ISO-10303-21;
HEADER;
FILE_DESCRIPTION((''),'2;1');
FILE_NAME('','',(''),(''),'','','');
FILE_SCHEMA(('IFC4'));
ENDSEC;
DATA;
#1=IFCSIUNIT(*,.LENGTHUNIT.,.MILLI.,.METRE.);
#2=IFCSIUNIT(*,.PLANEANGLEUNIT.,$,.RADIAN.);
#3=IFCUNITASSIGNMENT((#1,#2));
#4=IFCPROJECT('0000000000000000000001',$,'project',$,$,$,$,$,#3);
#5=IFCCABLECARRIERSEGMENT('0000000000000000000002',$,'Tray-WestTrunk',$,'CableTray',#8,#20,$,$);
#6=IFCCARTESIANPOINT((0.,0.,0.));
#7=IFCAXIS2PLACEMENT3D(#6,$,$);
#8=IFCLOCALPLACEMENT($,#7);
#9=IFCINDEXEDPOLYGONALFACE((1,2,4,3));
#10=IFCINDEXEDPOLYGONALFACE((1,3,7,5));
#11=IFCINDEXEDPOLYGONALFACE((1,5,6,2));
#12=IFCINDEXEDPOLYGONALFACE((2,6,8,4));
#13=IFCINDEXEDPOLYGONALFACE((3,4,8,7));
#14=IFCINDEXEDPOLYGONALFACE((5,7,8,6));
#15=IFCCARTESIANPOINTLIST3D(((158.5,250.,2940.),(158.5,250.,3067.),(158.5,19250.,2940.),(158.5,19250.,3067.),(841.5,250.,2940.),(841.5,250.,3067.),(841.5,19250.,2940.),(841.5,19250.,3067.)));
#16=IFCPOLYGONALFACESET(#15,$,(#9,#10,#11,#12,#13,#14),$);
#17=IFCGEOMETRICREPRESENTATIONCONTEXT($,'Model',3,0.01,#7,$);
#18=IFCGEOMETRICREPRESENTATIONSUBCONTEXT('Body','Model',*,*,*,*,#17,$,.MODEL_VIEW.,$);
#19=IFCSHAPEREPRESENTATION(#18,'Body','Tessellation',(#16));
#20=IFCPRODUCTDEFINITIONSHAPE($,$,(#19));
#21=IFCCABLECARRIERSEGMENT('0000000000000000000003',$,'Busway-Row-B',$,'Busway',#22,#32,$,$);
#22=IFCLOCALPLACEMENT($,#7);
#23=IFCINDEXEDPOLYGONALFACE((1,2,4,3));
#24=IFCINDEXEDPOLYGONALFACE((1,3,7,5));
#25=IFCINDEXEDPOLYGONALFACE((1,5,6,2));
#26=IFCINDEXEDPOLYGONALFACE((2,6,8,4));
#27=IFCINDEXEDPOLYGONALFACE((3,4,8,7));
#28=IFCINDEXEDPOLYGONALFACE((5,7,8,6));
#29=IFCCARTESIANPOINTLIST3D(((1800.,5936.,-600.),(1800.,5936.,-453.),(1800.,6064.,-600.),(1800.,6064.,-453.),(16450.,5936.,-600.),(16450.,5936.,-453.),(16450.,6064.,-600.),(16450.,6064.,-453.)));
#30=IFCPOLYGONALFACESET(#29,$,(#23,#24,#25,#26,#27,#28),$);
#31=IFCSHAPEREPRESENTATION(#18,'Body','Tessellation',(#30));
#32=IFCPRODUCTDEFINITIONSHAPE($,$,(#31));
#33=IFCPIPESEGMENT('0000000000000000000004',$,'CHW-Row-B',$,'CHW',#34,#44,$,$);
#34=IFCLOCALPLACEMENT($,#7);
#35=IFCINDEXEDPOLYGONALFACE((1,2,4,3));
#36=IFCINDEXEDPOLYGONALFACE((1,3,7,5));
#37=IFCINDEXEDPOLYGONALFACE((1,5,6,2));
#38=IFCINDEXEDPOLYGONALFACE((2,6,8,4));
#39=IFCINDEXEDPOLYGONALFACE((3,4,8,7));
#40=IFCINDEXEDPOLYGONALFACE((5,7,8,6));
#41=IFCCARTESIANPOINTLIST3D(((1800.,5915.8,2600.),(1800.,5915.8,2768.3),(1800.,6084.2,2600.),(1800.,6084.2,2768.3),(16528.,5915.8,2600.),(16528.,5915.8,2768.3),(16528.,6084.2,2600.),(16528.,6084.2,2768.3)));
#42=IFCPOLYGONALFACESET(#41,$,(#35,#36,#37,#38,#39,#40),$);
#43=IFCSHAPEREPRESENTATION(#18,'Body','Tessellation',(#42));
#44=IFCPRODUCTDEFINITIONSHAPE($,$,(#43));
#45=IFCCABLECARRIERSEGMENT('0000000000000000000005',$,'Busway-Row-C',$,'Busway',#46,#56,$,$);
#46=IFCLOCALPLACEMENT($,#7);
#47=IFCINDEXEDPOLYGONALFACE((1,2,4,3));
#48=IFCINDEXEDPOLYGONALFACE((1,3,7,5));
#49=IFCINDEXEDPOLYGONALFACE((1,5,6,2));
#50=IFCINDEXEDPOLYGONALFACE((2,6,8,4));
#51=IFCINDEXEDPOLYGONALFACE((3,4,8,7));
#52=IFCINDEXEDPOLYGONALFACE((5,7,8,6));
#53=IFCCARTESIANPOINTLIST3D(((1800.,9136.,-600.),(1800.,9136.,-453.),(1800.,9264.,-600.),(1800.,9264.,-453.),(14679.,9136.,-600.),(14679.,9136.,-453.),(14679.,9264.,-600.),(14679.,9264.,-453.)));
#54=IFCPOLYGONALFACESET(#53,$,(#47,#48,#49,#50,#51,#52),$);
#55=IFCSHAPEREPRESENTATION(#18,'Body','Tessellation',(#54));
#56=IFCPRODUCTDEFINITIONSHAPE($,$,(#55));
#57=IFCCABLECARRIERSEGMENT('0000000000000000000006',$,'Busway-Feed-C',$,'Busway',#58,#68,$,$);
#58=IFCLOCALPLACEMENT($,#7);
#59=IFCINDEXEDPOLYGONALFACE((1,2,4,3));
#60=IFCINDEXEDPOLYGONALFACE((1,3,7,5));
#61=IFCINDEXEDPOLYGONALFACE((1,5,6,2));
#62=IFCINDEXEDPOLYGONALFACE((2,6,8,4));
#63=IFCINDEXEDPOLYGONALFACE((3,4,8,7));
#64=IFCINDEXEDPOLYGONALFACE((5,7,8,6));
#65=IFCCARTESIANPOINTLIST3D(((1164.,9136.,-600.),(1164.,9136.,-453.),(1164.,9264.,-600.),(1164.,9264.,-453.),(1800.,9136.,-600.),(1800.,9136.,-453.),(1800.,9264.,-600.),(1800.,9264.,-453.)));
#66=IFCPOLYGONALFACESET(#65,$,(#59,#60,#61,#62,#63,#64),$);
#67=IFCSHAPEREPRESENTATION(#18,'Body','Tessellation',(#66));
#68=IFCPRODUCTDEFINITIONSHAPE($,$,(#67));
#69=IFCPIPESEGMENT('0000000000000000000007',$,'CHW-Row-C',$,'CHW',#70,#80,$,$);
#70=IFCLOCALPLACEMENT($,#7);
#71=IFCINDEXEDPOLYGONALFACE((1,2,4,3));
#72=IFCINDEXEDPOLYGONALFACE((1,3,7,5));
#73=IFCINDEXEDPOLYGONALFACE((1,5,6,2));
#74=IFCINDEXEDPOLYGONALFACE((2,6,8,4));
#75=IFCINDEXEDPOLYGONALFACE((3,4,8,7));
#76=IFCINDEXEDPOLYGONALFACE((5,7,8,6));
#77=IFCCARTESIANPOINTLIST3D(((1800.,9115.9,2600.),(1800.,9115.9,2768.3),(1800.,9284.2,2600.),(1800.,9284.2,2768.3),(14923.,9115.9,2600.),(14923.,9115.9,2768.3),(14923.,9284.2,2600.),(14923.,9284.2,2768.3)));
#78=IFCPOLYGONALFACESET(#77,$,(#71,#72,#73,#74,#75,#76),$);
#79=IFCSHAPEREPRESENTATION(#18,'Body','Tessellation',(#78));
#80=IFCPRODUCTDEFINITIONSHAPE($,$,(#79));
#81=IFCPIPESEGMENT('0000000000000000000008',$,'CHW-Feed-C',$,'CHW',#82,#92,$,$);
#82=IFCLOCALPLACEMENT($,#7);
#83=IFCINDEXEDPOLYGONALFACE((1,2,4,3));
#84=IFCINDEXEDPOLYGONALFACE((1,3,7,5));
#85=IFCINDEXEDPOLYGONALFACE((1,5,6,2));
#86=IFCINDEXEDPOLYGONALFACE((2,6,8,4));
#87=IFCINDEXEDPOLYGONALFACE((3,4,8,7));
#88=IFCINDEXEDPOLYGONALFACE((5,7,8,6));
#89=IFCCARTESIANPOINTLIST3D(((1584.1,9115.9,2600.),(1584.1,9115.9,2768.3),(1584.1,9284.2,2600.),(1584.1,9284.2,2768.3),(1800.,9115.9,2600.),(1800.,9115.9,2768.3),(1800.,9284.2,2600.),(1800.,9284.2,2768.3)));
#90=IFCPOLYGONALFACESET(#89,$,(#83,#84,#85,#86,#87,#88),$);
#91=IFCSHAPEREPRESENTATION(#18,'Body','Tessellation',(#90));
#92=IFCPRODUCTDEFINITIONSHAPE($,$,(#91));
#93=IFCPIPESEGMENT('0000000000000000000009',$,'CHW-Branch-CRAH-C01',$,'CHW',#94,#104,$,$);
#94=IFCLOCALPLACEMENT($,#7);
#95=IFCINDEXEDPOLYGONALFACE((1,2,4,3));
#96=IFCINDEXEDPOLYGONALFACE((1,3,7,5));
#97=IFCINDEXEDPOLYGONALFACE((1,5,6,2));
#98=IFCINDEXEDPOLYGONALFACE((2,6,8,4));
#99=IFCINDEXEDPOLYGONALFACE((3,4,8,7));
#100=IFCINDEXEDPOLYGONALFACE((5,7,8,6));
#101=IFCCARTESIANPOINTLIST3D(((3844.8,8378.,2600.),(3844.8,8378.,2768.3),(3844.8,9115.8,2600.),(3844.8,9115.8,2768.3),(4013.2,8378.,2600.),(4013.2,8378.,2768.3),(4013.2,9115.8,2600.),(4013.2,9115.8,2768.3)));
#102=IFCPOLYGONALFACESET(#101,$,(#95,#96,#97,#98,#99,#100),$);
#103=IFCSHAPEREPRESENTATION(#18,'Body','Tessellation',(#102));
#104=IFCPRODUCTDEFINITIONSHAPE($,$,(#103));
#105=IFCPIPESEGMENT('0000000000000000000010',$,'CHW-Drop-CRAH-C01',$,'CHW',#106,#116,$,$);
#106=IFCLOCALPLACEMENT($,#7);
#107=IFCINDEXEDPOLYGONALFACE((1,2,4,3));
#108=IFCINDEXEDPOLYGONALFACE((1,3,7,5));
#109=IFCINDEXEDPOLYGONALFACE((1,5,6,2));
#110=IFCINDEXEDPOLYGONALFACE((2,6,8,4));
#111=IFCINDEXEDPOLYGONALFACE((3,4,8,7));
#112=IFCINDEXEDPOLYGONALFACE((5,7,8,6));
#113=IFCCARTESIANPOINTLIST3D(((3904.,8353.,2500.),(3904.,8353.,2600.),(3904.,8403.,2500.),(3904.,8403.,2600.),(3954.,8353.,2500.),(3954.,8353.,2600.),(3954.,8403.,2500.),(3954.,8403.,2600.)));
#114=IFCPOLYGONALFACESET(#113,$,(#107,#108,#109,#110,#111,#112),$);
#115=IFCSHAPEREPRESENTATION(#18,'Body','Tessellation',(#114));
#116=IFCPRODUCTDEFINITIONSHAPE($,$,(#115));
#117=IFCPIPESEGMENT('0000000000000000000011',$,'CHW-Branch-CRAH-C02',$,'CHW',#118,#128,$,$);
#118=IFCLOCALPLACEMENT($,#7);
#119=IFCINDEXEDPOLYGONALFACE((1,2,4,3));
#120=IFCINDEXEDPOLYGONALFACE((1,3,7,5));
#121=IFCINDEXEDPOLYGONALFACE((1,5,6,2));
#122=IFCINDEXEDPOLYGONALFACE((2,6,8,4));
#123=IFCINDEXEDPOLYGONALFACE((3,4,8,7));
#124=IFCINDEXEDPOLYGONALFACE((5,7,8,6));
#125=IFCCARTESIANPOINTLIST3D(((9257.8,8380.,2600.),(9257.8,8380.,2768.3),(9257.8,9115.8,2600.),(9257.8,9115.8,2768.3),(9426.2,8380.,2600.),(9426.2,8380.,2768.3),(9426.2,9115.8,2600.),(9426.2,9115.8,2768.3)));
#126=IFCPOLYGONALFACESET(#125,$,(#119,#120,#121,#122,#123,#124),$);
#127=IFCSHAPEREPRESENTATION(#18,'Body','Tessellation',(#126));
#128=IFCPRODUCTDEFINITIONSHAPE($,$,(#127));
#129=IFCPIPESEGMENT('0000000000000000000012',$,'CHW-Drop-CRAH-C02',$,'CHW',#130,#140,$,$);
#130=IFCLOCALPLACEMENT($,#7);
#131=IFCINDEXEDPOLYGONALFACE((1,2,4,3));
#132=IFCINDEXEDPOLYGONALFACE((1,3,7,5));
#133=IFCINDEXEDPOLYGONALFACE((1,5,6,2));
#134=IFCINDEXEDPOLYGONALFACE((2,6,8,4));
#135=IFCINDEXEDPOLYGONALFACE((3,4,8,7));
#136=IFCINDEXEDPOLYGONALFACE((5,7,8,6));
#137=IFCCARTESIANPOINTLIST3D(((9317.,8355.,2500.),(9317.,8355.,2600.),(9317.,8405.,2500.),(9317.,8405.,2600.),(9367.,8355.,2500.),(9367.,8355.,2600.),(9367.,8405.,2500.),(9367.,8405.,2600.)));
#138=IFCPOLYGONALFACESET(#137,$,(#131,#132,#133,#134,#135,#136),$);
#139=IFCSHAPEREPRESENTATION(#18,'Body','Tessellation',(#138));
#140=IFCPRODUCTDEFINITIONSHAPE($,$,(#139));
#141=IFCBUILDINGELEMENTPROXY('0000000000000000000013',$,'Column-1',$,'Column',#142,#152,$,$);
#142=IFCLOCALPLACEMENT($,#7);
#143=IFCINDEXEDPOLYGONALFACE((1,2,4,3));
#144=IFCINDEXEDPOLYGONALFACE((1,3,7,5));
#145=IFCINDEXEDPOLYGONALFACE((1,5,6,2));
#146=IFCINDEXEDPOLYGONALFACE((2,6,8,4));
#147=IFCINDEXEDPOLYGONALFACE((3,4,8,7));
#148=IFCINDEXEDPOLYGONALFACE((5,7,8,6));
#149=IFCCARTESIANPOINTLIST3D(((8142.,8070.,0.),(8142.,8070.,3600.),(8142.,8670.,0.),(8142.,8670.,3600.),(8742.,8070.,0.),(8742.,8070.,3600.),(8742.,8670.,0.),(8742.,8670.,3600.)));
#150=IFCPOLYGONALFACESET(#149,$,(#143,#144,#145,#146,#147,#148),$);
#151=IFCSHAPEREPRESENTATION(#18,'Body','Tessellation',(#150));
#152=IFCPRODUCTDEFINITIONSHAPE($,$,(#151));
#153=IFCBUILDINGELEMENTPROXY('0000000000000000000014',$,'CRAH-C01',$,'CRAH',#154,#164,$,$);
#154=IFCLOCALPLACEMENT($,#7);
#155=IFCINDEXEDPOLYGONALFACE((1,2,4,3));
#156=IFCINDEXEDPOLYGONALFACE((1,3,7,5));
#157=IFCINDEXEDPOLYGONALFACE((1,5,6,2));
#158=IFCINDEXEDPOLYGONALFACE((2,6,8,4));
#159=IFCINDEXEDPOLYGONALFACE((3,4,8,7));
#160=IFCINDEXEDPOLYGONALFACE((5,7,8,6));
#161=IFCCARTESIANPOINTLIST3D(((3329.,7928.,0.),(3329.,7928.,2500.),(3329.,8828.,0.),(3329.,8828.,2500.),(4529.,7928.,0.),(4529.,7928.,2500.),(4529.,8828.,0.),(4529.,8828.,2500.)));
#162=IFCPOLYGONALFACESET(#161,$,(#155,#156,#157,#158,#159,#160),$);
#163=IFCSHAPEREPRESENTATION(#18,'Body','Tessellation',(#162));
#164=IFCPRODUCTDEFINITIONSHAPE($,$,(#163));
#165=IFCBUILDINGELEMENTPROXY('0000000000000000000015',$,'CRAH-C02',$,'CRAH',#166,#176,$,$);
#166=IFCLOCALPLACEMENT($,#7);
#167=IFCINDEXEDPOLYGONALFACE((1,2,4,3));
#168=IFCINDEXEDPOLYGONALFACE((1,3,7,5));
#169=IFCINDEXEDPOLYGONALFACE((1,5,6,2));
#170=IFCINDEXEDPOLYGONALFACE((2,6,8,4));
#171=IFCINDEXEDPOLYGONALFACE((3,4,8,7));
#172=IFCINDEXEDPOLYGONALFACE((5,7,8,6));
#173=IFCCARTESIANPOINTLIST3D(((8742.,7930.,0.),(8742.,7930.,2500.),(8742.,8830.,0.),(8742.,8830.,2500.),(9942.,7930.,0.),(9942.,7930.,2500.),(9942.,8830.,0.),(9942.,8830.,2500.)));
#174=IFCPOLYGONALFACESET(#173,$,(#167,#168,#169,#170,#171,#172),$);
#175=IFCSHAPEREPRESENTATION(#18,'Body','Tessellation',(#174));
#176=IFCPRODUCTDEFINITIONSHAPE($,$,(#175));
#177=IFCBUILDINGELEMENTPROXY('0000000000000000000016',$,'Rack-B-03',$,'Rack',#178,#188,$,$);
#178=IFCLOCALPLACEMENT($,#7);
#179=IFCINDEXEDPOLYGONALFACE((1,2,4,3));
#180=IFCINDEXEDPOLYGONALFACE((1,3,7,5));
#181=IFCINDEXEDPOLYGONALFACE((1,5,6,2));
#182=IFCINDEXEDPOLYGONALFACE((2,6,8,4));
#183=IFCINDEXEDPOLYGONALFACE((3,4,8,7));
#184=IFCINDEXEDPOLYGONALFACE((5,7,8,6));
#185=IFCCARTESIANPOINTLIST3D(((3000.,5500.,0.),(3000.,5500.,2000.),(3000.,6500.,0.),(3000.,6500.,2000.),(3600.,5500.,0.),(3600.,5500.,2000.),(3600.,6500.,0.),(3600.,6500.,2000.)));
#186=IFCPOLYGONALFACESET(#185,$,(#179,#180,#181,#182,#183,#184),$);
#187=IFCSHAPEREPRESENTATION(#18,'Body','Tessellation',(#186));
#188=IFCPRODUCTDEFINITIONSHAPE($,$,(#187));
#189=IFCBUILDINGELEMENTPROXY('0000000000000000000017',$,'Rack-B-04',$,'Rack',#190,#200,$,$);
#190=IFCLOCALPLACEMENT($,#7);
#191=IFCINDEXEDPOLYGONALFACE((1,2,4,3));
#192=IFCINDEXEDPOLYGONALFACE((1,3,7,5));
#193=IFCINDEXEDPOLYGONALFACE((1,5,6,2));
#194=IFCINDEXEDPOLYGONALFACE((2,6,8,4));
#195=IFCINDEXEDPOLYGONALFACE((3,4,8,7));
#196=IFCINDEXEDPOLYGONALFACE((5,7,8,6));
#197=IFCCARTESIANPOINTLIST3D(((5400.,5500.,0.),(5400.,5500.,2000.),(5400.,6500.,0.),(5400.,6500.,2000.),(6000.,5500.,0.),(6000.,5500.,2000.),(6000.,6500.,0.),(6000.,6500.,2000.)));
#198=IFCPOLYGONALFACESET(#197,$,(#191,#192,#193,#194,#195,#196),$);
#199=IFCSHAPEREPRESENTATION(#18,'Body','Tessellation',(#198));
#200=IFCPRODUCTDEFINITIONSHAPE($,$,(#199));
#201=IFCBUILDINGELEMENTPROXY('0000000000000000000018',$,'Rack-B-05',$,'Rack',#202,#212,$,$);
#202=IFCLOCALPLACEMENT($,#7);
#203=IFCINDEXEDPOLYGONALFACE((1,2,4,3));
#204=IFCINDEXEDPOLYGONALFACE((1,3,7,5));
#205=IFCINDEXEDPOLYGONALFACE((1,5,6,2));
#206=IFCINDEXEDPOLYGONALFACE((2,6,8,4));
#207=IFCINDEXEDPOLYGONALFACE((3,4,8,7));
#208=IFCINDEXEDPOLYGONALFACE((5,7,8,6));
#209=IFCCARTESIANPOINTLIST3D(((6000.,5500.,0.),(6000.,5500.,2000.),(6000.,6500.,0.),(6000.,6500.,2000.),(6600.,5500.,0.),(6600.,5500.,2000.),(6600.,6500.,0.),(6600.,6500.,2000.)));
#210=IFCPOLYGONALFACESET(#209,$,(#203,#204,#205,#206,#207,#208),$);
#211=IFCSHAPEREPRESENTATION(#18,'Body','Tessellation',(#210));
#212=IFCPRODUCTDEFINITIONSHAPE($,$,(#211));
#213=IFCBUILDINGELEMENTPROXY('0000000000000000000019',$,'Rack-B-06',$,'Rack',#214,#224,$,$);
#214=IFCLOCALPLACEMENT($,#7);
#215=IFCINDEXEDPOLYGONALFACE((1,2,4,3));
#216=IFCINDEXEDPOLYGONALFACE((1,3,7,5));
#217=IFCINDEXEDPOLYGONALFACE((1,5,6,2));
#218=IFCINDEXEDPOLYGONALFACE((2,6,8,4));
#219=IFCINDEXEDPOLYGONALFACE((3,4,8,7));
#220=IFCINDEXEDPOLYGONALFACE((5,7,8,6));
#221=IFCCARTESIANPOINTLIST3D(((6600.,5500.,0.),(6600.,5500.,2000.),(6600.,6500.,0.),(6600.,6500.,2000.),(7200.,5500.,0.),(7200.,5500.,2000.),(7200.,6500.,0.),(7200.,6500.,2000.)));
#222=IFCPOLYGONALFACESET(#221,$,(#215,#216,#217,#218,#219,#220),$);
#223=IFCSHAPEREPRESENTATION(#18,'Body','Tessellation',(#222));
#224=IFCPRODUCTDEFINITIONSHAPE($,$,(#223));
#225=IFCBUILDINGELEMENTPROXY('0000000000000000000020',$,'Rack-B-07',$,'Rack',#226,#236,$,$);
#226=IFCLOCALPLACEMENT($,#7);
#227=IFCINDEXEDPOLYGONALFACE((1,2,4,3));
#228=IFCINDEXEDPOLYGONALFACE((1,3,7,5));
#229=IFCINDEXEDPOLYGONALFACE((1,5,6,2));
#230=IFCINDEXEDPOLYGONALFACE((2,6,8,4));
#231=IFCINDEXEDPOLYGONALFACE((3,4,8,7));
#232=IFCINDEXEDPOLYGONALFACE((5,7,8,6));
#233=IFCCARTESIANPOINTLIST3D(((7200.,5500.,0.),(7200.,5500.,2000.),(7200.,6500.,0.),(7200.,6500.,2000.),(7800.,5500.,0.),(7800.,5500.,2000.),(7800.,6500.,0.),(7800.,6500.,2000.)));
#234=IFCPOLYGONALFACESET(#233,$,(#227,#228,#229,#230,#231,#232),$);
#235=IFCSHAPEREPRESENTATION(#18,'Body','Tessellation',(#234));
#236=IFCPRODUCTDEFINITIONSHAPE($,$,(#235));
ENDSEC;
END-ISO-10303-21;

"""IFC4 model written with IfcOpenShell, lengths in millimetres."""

from ifc_helpers import new_model, si_unit, frame, origin, place, context, subcontext, project, rectangle, extrude, element, save


model = new_model("IFC4")

# Units and contexts
model_context = context("Model", 3, precision=0.01, world=origin())
body_context = subcontext(model_context, "Body", "Model", "MODEL_VIEW")
ifc_project = project(units=[si_unit("LENGTHUNIT", "METRE", prefix="MILLI"), si_unit("PLANEANGLEUNIT", "RADIAN")])

# Cable carrier segments
placement = place(None, origin())
cable_carrier_segment_1_placement = place(placement, frame((500.0, 9750.0, 2940.0)))
element("IfcCableCarrierSegment", 1, at=cable_carrier_segment_1_placement, Name="Tray-WestTrunk", ObjectType="CableTray", context=body_context, shape_type="SweptSolid", body=[
    extrude(rectangle(XDim=683.0, YDim=19000.0), origin(), (0.0, 0.0, 1.0), 127.0),
])
cable_carrier_segment_2_placement = place(placement, frame((9125.0, 6000.0, -600.0)))
element("IfcCableCarrierSegment", 2, at=cable_carrier_segment_2_placement, Name="Busway-Row-B", ObjectType="Busway", context=body_context, shape_type="SweptSolid", body=[
    extrude(rectangle(XDim=14650.0, YDim=128.0), origin(), (0.0, 0.0, 1.0), 147.0),
])

# Pipe segment
pipe_segment_1_placement = place(placement, frame((9164.0, 6000.0, 2600.0)))
element("IfcPipeSegment", 3, at=pipe_segment_1_placement, Name="CHW-Row-B", ObjectType="CHW", context=body_context, shape_type="SweptSolid", body=[
    extrude(rectangle(XDim=14728.0, YDim=168.3), origin(), (0.0, 0.0, 1.0), 168.3),
])

# Cable carrier segments
cable_carrier_segment_3_placement = place(placement, frame((8239.5, 9200.0, -600.0)))
element("IfcCableCarrierSegment", 4, at=cable_carrier_segment_3_placement, Name="Busway-Row-C", ObjectType="Busway", context=body_context, shape_type="SweptSolid", body=[
    extrude(rectangle(XDim=12879.0, YDim=128.0), origin(), (0.0, 0.0, 1.0), 147.0),
])
cable_carrier_segment_4_placement = place(placement, frame((1482.0, 9200.0, -600.0)))
element("IfcCableCarrierSegment", 5, at=cable_carrier_segment_4_placement, Name="Busway-Feed-C", ObjectType="Busway", context=body_context, shape_type="SweptSolid", body=[
    extrude(rectangle(XDim=636.0, YDim=128.0), origin(), (0.0, 0.0, 1.0), 147.0),
])

# Pipe segments
pipe_segment_2_placement = place(placement, frame((8361.5, 9200.0, 2600.0)))
element("IfcPipeSegment", 6, at=pipe_segment_2_placement, Name="CHW-Row-C", ObjectType="CHW", context=body_context, shape_type="SweptSolid", body=[
    extrude(rectangle(XDim=13123.0, YDim=168.3), origin(), (0.0, 0.0, 1.0), 168.3),
])
pipe_segment_3_placement = place(placement, frame((1692.1, 9200.0, 2600.0)))
element("IfcPipeSegment", 7, at=pipe_segment_3_placement, Name="CHW-Feed-C", ObjectType="CHW", context=body_context, shape_type="SweptSolid", body=[
    extrude(rectangle(XDim=215.8, YDim=168.3), origin(), (0.0, 0.0, 1.0), 168.3),
])
pipe_segment_4_placement = place(placement, frame((3929.0, 8746.9, 2600.0)))
element("IfcPipeSegment", 8, at=pipe_segment_4_placement, Name="CHW-Branch-CRAH-C01", ObjectType="CHW", context=body_context, shape_type="SweptSolid", body=[
    extrude(rectangle(XDim=168.3, YDim=737.9), origin(), (0.0, 0.0, 1.0), 168.3),
])
pipe_segment_5_placement = place(placement, frame((3929.0, 8378.0, 2500.0)))
element("IfcPipeSegment", 9, at=pipe_segment_5_placement, Name="CHW-Drop-CRAH-C01", ObjectType="CHW", context=body_context, shape_type="SweptSolid", body=[
    extrude(rectangle(XDim=50.0, YDim=50.0), origin(), (0.0, 0.0, 1.0), 100.0),
])
pipe_segment_6_placement = place(placement, frame((9342.0, 8747.9, 2600.0)))
element("IfcPipeSegment", 10, at=pipe_segment_6_placement, Name="CHW-Branch-CRAH-C02", ObjectType="CHW", context=body_context, shape_type="SweptSolid", body=[
    extrude(rectangle(XDim=168.3, YDim=735.9), origin(), (0.0, 0.0, 1.0), 168.3),
])
pipe_segment_7_placement = place(placement, frame((9342.0, 8380.0, 2500.0)))
element("IfcPipeSegment", 11, at=pipe_segment_7_placement, Name="CHW-Drop-CRAH-C02", ObjectType="CHW", context=body_context, shape_type="SweptSolid", body=[
    extrude(rectangle(XDim=50.0, YDim=50.0), origin(), (0.0, 0.0, 1.0), 100.0),
])

# Building element proxies
proxy_placement = place(placement, frame((8442.0, 8370.0, 0.0)))
element("IfcBuildingElementProxy", 12, at=proxy_placement, Name="Column-1", ObjectType="Column", context=body_context, shape_type="SweptSolid", body=[
    extrude(rectangle(XDim=600.0, YDim=600.0), origin(), (0.0, 0.0, 1.0), 3600.0),
])
for number, where, name in (
    (13, (3929.0, 8378.0, 0.0), "CRAH-C01"),
    (14, (9342.0, 8380.0, 0.0), "CRAH-C02"),
):
    element("IfcBuildingElementProxy", number, at=place(placement, frame(where)), Name=name, ObjectType="CRAH", context=body_context, shape_type="SweptSolid", body=[
        extrude(rectangle(XDim=1200.0, YDim=900.0), origin(), (0.0, 0.0, 1.0), 2500.0),
    ])
for number, where, name in (
    (15, (3300.0, 6000.0, 0.0), "Rack-B-03"),
    (16, (5700.0, 6000.0, 0.0), "Rack-B-04"),
    (17, (6300.0, 6000.0, 0.0), "Rack-B-05"),
    (18, (6900.0, 6000.0, 0.0), "Rack-B-06"),
    (19, (7500.0, 6000.0, 0.0), "Rack-B-07"),
):
    element("IfcBuildingElementProxy", number, at=place(placement, frame(where)), Name=name, ObjectType="Rack", context=body_context, shape_type="SweptSolid", body=[
        extrude(rectangle(XDim=600.0, YDim=1000.0), origin(), (0.0, 0.0, 1.0), 2000.0),
    ])

save(model, "model.ifc")
